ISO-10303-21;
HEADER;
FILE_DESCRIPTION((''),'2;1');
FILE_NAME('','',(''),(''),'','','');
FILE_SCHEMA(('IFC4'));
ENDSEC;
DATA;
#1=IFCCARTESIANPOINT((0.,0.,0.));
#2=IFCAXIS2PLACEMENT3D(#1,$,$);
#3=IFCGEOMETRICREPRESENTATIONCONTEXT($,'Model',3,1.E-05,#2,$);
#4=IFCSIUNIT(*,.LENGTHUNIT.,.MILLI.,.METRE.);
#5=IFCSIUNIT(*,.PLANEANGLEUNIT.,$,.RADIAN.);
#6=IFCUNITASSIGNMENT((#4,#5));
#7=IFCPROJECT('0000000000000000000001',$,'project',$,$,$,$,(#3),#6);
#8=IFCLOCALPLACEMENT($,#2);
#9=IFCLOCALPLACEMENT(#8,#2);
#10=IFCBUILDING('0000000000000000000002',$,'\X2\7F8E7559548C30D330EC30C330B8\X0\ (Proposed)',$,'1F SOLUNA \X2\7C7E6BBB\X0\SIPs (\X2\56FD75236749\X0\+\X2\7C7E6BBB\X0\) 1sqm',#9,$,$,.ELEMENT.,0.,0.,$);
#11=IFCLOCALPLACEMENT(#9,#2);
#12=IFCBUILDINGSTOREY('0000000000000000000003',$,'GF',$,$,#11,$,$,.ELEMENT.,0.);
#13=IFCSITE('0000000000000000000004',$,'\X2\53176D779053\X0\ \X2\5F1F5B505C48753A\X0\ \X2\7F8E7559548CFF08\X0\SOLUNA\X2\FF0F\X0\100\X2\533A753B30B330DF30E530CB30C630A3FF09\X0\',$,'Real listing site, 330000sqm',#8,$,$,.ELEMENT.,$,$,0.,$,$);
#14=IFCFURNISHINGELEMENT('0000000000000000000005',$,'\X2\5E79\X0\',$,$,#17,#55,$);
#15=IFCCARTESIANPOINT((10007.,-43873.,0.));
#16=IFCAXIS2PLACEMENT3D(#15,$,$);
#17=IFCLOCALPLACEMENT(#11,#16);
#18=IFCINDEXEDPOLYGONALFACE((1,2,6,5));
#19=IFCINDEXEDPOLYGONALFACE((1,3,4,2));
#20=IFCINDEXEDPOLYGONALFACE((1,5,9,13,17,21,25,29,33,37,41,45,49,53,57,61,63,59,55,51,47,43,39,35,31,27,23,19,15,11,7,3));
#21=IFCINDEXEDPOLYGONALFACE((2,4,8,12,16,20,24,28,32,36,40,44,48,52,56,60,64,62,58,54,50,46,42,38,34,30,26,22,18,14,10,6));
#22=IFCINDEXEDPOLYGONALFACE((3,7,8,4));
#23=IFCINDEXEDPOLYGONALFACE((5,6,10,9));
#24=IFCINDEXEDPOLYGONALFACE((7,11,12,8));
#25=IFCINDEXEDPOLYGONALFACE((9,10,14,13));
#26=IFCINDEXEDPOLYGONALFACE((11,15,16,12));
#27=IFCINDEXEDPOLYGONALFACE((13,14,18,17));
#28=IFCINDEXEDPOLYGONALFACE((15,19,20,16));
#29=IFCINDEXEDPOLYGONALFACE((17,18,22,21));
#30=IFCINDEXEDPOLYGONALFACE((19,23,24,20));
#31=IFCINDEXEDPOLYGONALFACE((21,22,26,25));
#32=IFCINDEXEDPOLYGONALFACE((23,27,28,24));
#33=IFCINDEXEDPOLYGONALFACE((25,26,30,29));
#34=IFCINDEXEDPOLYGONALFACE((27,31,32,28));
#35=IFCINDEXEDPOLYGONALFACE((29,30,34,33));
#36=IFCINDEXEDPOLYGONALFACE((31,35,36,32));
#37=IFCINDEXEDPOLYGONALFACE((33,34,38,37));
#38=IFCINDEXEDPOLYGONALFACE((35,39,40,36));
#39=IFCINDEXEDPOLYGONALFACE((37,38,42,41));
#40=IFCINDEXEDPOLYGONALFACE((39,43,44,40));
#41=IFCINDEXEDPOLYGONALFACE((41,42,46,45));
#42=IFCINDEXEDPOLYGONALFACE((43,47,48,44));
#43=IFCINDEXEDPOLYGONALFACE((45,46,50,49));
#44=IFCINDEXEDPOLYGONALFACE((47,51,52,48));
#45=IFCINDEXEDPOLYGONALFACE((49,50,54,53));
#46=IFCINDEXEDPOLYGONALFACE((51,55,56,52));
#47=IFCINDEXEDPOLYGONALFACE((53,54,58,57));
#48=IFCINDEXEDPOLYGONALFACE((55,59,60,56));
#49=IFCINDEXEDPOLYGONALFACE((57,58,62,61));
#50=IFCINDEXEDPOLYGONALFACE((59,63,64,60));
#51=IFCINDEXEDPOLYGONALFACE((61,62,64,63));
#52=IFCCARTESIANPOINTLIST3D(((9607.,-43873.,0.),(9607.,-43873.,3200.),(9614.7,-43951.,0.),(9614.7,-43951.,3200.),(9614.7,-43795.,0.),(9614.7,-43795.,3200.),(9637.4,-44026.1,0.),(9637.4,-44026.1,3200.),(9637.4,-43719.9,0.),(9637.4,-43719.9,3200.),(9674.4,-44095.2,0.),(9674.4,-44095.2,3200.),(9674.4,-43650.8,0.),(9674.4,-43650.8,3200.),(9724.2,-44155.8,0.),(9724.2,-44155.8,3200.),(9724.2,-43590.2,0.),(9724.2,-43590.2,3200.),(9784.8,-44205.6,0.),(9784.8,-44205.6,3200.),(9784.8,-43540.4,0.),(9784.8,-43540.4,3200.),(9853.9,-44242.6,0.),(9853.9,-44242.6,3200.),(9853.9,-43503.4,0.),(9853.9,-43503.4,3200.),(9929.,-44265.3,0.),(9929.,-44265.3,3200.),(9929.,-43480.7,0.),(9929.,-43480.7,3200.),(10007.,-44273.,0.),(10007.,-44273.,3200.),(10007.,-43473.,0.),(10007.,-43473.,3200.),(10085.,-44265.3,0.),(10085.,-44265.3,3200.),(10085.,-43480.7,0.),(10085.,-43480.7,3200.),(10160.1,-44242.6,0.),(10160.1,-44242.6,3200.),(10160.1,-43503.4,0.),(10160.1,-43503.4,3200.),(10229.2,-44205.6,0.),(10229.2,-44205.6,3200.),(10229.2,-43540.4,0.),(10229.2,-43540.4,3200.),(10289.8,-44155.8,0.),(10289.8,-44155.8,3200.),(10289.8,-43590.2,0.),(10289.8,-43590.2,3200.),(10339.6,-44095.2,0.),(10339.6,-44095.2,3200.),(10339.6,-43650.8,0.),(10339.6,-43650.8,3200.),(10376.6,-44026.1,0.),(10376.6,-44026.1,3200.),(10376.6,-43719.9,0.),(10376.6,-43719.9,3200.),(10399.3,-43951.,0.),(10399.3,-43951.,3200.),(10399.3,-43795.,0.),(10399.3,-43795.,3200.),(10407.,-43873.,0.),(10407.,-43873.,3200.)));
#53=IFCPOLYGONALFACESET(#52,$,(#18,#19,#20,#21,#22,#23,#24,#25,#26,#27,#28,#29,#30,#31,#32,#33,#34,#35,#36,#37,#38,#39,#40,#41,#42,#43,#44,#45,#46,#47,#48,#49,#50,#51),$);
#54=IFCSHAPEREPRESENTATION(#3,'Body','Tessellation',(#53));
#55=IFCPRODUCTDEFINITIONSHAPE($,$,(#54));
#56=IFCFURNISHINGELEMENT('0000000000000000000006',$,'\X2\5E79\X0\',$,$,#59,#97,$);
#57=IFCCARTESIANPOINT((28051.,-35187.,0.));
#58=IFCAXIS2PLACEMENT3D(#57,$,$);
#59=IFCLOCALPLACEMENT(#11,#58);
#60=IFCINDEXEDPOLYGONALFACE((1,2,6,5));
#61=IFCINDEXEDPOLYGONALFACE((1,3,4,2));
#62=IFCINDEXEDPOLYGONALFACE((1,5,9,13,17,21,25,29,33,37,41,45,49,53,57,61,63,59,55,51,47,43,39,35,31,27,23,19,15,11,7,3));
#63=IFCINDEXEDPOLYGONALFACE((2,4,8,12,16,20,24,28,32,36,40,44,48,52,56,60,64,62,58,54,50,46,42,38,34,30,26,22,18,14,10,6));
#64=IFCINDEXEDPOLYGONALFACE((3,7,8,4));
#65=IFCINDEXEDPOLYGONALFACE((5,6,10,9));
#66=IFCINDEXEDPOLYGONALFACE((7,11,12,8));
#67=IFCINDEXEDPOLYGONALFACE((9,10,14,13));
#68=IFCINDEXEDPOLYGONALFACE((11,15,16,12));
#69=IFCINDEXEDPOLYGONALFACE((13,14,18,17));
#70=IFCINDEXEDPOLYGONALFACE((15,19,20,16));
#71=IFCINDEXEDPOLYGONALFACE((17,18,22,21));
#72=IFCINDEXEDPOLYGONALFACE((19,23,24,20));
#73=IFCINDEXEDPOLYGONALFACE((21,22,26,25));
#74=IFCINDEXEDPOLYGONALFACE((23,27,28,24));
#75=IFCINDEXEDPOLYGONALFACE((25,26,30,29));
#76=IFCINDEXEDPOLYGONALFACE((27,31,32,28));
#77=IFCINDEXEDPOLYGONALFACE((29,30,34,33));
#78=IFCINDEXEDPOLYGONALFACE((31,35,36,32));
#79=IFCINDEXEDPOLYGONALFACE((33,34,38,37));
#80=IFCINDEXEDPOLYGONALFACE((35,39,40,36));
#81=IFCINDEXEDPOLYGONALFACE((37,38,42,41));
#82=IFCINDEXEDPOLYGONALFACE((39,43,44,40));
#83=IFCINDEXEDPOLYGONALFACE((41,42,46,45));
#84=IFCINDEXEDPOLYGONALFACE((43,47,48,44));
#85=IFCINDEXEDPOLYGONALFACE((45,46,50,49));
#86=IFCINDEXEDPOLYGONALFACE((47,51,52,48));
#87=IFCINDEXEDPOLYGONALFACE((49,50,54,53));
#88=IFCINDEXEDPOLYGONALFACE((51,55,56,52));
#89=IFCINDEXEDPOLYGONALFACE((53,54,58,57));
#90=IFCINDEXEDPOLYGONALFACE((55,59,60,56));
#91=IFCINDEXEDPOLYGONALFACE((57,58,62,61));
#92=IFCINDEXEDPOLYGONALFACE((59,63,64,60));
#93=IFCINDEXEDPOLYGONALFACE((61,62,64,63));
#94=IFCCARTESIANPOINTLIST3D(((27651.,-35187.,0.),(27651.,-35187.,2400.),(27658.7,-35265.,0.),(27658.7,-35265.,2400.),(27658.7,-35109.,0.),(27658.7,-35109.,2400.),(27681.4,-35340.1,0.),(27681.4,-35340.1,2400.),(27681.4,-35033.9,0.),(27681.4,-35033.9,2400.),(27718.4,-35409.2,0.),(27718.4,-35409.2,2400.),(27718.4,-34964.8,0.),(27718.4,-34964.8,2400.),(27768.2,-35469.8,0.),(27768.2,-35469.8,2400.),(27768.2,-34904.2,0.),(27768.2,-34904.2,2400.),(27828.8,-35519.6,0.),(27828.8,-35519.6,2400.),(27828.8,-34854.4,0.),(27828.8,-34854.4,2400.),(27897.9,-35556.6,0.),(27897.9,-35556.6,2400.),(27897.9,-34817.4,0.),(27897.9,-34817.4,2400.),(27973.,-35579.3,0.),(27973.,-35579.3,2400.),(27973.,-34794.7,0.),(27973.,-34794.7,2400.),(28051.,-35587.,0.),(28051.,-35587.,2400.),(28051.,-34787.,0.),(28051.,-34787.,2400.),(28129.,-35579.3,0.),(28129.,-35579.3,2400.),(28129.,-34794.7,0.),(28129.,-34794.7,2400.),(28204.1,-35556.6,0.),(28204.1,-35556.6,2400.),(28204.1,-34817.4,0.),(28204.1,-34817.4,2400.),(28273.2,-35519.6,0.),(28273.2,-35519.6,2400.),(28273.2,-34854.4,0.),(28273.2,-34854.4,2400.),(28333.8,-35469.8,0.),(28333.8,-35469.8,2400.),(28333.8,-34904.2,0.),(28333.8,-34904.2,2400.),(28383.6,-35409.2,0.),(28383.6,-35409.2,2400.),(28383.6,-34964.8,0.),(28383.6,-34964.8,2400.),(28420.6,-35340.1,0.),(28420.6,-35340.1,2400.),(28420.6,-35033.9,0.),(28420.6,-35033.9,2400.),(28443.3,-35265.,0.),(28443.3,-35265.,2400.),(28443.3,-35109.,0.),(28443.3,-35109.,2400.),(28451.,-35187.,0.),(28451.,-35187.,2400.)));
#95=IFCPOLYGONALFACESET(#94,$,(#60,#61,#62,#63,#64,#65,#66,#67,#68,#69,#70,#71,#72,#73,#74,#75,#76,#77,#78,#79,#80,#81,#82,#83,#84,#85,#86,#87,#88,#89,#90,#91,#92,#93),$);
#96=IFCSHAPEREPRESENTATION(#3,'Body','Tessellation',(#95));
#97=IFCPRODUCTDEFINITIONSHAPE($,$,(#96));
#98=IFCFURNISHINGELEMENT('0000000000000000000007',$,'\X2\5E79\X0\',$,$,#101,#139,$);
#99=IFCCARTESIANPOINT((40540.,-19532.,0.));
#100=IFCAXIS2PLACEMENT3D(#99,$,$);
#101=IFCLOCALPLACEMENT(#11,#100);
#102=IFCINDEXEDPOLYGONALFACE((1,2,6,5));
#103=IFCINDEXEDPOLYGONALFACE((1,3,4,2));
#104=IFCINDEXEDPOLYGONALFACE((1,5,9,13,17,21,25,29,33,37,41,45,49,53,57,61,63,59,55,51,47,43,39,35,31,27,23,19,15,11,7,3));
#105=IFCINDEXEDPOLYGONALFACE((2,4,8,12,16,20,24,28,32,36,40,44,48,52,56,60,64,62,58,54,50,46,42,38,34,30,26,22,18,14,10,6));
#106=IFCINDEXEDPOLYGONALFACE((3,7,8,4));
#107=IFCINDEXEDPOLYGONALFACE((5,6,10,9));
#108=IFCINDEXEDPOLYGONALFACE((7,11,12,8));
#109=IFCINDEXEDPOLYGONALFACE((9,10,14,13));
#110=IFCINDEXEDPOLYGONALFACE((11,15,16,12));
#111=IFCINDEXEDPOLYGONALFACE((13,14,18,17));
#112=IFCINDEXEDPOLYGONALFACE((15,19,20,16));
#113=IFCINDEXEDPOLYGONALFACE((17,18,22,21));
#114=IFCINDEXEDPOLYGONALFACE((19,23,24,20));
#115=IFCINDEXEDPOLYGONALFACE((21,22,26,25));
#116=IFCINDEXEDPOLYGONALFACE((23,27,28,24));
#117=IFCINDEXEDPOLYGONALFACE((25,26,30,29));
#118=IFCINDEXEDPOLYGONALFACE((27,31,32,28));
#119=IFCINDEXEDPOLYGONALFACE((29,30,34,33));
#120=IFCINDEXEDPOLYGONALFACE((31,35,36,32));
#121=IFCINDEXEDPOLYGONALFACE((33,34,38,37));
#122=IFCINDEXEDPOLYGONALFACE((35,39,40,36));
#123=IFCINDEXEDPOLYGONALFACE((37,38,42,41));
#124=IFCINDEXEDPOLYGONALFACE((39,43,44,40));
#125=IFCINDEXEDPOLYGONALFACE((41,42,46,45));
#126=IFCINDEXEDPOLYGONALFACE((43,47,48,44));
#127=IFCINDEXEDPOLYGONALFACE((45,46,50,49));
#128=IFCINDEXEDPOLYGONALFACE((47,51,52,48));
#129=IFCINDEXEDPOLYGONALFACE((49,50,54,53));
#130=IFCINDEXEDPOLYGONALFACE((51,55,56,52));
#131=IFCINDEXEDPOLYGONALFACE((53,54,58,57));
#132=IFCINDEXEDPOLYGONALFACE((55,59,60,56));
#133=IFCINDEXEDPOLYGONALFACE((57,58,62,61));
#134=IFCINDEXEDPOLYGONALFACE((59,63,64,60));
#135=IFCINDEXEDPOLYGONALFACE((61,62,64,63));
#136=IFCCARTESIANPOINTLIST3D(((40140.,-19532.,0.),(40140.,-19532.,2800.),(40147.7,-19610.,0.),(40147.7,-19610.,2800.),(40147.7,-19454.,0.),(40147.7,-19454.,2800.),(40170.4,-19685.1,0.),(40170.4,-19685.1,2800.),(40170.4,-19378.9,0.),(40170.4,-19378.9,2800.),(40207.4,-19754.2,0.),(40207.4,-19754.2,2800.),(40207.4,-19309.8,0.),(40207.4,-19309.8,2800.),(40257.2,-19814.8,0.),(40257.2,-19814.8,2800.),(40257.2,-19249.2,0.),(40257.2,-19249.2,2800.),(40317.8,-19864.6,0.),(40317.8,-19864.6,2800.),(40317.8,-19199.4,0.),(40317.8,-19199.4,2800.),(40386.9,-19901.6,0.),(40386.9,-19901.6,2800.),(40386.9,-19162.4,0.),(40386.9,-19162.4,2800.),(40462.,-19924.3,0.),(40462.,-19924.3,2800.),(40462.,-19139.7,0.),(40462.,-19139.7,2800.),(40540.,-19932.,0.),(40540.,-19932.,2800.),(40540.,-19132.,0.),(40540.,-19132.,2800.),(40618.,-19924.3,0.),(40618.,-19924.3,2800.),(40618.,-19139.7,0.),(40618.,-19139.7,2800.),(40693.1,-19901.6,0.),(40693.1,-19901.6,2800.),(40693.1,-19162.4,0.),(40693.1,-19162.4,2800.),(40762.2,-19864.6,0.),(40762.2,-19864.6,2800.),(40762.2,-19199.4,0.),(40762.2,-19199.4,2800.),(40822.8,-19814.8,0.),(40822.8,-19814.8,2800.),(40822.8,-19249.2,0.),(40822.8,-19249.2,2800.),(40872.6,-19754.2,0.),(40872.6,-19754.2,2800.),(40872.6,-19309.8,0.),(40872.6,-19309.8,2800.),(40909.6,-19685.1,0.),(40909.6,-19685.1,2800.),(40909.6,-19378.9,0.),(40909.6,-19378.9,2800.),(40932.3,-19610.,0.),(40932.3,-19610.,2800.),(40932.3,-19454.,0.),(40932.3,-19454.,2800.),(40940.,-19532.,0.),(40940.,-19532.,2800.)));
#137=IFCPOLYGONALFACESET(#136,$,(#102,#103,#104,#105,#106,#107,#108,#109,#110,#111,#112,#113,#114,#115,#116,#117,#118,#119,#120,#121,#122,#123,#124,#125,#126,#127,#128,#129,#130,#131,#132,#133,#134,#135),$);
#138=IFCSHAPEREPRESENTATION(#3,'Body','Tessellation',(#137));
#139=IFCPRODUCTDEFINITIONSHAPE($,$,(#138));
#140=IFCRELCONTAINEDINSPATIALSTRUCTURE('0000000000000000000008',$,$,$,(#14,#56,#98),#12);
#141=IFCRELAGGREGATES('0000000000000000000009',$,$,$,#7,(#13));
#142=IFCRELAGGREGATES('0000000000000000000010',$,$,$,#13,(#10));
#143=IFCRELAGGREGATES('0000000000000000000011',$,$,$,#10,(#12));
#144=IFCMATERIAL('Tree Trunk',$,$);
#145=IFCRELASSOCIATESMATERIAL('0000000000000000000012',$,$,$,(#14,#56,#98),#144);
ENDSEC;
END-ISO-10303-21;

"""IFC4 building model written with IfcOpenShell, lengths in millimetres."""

from ifc_helpers import new_model, si_unit, frame, origin, origin_2d, place, context, project, spatial, circle, extrude, material, element, save


model = new_model("IFC4")

# Units and contexts
model_context = context("Model", 3, precision=1e-05, world=origin())
ifc_project = project(units=[si_unit("LENGTHUNIT", "METRE", prefix="MILLI"), si_unit("PLANEANGLEUNIT", "RADIAN")], contexts=[model_context])

# Site, building, storey
site_placement = place(None, origin())
site = spatial("IfcSite", under=ifc_project, at=site_placement, Name="北海道 弟子屈町 美留和（SOLUNA／100区画コミュニティ）", ObjectType="Real listing site, 330000sqm", CompositionType="ELEMENT", RefElevation=0.0)
building_placement = place(site_placement, origin())
building = spatial("IfcBuilding", under=site, at=building_placement, Name="美留和ビレッジ (Proposed)", ObjectType="1F SOLUNA 籾殻SIPs (国産杉+籾殻) 1sqm", CompositionType="ELEMENT", ElevationOfRefHeight=0.0, ElevationOfTerrain=0.0)
storey_placement = place(building_placement, origin())
storey = spatial("IfcBuildingStorey", under=building, at=storey_placement, Name="GF", CompositionType="ELEMENT", Elevation=0.0)

# Furnishing elements
ifc_material_1 = material(Name="Tree Trunk")
furnishing_1_placement = place(storey_placement, frame((10007.0, -43873.0, 0.0)))
element("IfcFurnishingElement", 1, at=furnishing_1_placement, inside=storey, material=ifc_material_1, Name="幹", context=model_context, shape_type="SweptSolid", body=[
    extrude(circle(Radius=400.0, at=origin_2d()), frame((10007.0, -43873.0, 0.0)), (0.0, 0.0, 1.0), 3200.0),
])
furnishing_2_placement = place(storey_placement, frame((28051.0, -35187.0, 0.0)))
element("IfcFurnishingElement", 2, at=furnishing_2_placement, inside=storey, material=ifc_material_1, Name="幹", context=model_context, shape_type="SweptSolid", body=[
    extrude(circle(Radius=400.0, at=origin_2d()), frame((28051.0, -35187.0, 0.0)), (0.0, 0.0, 1.0), 2400.0),
])
furnishing_3_placement = place(storey_placement, frame((40540.0, -19532.0, 0.0)))
element("IfcFurnishingElement", 3, at=furnishing_3_placement, inside=storey, material=ifc_material_1, Name="幹", context=model_context, shape_type="SweptSolid", body=[
    extrude(circle(Radius=400.0, at=origin_2d()), frame((40540.0, -19532.0, 0.0)), (0.0, 0.0, 1.0), 2800.0),
])

save(model, "model.ifc")
